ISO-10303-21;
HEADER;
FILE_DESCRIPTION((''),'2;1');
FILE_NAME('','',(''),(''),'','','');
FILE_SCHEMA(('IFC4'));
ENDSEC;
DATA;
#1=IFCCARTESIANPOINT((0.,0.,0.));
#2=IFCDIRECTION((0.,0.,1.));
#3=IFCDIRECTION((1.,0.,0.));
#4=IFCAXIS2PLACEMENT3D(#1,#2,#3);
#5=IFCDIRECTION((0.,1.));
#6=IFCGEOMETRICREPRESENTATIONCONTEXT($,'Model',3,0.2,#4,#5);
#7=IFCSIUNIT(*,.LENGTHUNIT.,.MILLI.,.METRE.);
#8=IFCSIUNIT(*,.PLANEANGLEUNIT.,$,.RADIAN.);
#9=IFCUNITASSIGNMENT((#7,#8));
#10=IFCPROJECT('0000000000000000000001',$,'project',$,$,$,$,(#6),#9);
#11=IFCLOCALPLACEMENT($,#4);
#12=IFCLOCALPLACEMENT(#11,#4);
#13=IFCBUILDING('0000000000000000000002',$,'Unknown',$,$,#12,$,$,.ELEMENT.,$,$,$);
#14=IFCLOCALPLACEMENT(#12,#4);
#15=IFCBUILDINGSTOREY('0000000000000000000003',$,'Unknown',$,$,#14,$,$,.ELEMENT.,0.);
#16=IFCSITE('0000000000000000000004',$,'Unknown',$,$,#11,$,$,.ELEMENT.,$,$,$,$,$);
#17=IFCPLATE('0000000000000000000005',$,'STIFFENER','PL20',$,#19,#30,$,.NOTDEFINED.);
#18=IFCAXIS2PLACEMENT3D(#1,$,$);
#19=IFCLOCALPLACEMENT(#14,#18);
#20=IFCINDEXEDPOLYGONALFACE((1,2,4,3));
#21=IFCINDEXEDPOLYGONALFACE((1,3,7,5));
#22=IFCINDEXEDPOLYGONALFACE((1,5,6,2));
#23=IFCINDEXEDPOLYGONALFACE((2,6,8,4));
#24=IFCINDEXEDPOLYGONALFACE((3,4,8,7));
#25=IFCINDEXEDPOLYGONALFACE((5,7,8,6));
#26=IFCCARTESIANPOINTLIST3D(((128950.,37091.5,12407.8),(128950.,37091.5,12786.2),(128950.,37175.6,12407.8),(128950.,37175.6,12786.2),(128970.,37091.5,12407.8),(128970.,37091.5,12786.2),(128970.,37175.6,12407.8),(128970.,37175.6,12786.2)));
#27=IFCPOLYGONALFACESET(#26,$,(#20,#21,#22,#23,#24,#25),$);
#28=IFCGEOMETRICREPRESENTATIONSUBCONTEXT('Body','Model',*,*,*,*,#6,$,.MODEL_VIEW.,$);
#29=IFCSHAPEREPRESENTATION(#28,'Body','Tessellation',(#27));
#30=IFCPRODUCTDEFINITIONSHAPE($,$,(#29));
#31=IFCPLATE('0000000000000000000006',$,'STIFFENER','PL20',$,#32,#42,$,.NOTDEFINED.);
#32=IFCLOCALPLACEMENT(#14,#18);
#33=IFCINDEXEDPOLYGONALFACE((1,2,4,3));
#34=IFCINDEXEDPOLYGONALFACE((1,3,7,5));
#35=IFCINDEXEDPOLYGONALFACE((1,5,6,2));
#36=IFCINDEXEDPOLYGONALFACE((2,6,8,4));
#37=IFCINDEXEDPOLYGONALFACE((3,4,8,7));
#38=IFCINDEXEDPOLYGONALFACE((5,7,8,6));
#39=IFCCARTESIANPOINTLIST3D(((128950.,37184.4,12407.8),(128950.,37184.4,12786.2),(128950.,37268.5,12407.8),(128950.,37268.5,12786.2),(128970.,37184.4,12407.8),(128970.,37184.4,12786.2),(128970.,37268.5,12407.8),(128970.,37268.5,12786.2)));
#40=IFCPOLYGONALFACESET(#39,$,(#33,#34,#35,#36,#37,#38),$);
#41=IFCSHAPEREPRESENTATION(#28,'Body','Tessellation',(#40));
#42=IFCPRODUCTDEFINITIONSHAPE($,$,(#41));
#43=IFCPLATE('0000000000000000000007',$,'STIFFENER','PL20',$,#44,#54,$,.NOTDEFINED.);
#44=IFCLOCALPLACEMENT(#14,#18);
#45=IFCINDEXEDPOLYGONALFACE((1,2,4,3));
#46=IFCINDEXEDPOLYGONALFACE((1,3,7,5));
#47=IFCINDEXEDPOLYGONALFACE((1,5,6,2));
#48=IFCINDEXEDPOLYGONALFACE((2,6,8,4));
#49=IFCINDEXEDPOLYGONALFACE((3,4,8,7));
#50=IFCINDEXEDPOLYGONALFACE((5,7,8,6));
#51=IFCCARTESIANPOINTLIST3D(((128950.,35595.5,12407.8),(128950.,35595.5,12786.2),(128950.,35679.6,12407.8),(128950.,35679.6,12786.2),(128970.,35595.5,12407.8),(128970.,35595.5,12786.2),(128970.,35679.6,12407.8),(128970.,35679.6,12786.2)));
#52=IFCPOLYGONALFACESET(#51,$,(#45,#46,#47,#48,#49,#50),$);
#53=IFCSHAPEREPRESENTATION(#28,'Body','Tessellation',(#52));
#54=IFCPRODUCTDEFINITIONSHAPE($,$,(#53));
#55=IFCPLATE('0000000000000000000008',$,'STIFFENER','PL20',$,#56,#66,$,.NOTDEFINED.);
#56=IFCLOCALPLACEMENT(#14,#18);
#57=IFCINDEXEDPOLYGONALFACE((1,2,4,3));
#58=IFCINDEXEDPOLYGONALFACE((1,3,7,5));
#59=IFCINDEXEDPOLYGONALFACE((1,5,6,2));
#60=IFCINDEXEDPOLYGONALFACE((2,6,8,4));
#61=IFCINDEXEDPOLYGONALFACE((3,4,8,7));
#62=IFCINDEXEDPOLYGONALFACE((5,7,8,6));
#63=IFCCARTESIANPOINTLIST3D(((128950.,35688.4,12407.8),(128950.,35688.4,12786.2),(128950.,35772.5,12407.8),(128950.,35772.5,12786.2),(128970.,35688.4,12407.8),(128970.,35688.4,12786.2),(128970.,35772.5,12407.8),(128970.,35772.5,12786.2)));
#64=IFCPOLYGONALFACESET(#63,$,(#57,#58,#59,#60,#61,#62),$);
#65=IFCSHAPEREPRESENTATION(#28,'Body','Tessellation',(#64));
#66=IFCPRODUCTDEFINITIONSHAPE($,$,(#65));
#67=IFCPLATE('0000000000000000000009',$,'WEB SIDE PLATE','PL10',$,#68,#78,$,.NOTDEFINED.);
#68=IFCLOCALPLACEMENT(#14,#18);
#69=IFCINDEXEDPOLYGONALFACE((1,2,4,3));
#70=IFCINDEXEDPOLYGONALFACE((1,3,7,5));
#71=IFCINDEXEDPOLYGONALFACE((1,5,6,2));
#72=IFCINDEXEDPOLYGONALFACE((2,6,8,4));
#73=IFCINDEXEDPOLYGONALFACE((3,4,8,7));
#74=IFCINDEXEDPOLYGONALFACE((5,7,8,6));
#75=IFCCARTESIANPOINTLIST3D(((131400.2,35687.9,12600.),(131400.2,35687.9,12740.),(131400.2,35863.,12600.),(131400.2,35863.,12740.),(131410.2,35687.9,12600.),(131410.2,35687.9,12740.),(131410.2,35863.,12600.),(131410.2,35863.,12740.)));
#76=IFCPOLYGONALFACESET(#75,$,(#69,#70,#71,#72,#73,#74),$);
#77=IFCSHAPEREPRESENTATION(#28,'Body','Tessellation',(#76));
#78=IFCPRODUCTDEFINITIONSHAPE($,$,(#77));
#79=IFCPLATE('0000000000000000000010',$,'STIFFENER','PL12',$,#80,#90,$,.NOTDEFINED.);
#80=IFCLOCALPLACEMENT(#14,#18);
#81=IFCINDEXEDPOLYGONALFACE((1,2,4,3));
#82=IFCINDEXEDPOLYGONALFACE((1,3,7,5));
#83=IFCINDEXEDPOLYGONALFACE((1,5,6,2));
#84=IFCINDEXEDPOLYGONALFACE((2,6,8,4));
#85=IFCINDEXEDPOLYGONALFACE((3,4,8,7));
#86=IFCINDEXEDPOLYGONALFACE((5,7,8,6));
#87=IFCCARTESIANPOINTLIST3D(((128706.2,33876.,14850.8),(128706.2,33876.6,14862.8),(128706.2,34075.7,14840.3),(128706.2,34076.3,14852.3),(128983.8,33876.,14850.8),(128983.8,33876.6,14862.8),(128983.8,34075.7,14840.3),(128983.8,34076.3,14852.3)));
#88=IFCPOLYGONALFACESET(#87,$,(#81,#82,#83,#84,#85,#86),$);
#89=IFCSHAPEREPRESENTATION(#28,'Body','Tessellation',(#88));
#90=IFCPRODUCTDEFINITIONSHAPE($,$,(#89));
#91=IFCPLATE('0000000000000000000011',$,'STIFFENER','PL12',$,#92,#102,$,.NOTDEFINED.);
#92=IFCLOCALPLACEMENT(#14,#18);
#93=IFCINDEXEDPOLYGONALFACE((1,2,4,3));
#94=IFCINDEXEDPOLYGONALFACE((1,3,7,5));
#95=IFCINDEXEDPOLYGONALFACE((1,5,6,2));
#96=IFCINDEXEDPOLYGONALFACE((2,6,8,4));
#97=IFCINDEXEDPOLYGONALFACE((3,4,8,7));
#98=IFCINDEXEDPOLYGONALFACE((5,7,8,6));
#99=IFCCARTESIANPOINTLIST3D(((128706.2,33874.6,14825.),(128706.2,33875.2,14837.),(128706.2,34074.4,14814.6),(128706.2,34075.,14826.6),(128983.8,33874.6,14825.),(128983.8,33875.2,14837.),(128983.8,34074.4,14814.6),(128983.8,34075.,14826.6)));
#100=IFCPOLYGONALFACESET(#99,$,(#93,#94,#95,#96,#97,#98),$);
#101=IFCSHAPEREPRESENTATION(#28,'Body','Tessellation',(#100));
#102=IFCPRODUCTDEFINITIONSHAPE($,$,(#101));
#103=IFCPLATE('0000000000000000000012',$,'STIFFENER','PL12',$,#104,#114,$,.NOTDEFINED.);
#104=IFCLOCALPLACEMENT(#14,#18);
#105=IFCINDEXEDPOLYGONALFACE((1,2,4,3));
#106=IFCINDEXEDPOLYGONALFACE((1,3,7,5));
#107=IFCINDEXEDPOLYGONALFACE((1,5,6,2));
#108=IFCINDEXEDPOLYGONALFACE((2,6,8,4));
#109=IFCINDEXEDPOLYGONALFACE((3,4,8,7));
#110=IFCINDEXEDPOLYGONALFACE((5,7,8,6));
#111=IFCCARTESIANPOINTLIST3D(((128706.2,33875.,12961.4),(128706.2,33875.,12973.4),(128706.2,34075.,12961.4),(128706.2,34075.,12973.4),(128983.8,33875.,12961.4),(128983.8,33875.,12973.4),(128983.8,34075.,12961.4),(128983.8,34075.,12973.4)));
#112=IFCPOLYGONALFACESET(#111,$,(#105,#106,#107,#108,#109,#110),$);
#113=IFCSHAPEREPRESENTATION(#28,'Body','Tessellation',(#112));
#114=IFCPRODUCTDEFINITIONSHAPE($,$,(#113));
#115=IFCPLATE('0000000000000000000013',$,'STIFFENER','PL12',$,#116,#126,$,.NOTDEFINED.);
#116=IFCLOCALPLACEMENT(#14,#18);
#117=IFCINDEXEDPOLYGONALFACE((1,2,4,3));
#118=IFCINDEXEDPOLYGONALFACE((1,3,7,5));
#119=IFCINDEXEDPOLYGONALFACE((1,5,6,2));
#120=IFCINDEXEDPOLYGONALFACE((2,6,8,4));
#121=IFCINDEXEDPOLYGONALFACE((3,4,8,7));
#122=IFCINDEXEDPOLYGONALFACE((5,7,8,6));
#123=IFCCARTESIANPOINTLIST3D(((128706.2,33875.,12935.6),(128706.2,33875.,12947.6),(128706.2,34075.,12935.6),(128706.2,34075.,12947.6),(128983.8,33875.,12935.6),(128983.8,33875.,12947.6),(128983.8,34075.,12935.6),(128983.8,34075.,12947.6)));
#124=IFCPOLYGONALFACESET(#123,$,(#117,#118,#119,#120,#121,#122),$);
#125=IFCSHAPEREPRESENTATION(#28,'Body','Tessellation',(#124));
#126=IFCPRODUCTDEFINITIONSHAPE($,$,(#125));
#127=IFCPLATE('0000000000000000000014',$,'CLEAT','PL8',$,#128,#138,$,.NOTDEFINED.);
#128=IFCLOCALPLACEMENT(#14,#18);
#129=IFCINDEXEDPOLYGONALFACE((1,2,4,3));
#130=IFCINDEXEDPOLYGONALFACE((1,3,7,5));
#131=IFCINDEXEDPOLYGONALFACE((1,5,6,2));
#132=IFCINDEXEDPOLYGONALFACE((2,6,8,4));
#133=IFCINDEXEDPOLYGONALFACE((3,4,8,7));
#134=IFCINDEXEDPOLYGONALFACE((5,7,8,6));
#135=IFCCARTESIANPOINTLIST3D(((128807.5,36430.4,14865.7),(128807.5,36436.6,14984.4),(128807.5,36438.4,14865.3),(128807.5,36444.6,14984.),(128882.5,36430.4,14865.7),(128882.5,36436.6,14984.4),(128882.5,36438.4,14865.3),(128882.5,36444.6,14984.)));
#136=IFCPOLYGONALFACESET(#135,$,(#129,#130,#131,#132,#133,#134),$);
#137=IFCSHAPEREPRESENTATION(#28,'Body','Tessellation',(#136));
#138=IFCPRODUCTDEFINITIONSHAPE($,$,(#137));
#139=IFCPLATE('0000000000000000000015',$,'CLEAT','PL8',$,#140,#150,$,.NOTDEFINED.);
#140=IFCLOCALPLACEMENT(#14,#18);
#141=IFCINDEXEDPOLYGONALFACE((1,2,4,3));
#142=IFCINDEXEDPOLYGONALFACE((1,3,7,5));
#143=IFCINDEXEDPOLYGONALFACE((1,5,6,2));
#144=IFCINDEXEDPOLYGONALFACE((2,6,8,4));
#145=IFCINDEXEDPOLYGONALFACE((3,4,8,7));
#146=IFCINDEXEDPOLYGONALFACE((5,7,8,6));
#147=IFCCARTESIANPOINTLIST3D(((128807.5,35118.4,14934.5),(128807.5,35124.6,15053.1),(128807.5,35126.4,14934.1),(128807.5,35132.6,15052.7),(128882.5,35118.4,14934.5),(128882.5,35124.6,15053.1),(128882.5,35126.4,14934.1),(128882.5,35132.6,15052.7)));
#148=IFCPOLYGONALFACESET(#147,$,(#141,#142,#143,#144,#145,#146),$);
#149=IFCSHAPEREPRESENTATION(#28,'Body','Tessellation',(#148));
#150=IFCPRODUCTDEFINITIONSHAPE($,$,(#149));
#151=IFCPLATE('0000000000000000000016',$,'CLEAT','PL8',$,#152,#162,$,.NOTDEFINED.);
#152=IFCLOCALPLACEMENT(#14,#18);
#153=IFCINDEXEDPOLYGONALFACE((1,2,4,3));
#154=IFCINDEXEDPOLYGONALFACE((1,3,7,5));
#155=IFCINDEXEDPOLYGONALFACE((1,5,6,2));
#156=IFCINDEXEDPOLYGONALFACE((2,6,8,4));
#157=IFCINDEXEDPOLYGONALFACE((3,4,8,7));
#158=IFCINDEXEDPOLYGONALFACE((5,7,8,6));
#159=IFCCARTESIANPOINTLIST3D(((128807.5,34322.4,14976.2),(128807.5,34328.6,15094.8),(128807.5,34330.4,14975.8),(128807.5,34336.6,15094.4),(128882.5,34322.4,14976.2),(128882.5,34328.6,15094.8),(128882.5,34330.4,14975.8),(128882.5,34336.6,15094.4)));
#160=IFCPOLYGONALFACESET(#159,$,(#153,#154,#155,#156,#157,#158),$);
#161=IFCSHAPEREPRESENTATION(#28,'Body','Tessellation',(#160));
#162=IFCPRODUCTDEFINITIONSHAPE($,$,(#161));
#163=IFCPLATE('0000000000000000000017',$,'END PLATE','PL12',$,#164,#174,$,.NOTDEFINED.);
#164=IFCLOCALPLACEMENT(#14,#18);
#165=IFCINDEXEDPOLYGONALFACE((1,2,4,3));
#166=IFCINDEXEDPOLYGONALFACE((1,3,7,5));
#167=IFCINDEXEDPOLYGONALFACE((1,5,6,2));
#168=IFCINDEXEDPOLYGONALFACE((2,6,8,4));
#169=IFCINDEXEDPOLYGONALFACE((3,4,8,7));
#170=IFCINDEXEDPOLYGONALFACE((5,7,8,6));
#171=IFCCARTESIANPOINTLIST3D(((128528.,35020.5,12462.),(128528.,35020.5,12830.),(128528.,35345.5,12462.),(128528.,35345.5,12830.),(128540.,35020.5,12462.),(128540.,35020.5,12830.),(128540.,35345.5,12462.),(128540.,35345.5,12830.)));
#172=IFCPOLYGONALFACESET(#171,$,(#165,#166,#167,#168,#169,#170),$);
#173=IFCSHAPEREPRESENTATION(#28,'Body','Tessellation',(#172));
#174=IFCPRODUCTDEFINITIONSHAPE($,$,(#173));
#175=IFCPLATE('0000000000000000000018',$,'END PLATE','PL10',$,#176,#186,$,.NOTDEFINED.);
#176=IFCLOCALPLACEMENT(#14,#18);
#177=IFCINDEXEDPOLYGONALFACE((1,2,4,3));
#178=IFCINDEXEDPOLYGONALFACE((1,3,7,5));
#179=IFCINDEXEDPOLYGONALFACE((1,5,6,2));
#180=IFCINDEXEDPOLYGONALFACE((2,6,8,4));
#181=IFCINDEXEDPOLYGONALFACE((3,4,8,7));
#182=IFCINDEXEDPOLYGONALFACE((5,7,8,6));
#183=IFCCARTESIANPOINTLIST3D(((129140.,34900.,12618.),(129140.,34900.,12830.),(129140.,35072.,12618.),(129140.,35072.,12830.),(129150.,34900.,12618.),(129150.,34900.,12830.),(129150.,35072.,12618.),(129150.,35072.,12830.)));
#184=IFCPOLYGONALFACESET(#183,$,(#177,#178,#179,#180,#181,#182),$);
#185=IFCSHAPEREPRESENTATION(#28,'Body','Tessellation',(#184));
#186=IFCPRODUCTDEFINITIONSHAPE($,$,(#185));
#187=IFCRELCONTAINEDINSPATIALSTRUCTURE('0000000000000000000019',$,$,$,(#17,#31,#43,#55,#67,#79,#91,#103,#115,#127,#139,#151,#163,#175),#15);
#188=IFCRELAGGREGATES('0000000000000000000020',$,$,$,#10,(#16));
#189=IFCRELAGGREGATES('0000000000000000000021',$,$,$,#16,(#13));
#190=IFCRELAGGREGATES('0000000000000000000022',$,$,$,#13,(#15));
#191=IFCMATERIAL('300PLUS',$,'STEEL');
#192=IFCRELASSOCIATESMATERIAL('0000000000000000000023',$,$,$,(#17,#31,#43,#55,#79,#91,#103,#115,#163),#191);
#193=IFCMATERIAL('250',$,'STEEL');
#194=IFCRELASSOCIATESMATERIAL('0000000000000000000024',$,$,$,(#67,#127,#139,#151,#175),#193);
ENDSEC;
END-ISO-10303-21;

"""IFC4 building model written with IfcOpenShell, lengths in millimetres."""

from ifc_helpers import new_model, si_unit, direction, frame, origin_with_axes, place, context, subcontext, project, spatial, line, indexed_curve, outline, extrude, material, element, save


model = new_model("IFC4")

# Units and contexts
model_context = context("Model", 3, precision=0.2, world=origin_with_axes(), true_north=direction((0.0, 1.0)))
body_context = subcontext(model_context, "Body", "Model", "MODEL_VIEW")
ifc_project = project(units=[si_unit("LENGTHUNIT", "METRE", prefix="MILLI"), si_unit("PLANEANGLEUNIT", "RADIAN")], contexts=[model_context])

# Site, building, storey
site_placement = place(None, origin_with_axes())
site = spatial("IfcSite", under=ifc_project, at=site_placement, Name="Unknown", CompositionType="ELEMENT")
building_placement = place(site_placement, origin_with_axes())
building = spatial("IfcBuilding", under=site, at=building_placement, Name="Unknown", CompositionType="ELEMENT")
storey_placement = place(building_placement, origin_with_axes())
storey = spatial("IfcBuildingStorey", under=building, at=storey_placement, Name="Unknown", CompositionType="ELEMENT", Elevation=0.0)

# Shared definitions
ifc_material_1 = material(Name="300PLUS", Category="STEEL")

# Plates
for number, where, z_axis, x_axis, name in (
    (1, (128960.0, 37175.6, 12407.8), (1.0, 0.0, 0.0), (0.0, 0.0, 1.0), "STIFFENER"),
    (2, (128960.0, 37268.5, 12407.8), (1.0, 0.0, 0.0), (0.0, 0.0, 1.0), "STIFFENER"),
    (3, (128960.0, 35679.6, 12407.8), (1.0, 0.0, 0.0), (0.0, 0.0, 1.0), "STIFFENER"),
    (4, (128960.0, 35772.5, 12407.8), (1.0, 0.0, 0.0), (0.0, 0.0, 1.0), "STIFFENER"),
):
    element("IfcPlate", number, at=place(storey_placement, frame(where, z_axis=z_axis, x_axis=x_axis)), inside=storey, material=ifc_material_1, Name=name, Description="PL20", PredefinedType="NOTDEFINED", context=body_context, shape_type="SolidModel", body=[
        extrude(outline(indexed_curve([(0.0, 0.0), (378.4, 0.0), (378.4, 84.1), (0.0, 84.1)], segments=[line(1, 2, 3, 4, 1)])), frame((0.0, 0.0, 10.0), z_axis=(0.0, 0.0, 1.0), x_axis=(1.0, 0.0, 0.0)), (0.0, 0.0, -1.0), 20.0),
    ])
ifc_material_2 = material(Name="250", Category="STEEL")
plate_1_placement = place(storey_placement, frame((131405.2, 35863.0, 12600.0), z_axis=(1.0, 0.0, 0.0), x_axis=(0.0, 0.0, 1.0)))
element("IfcPlate", 5, at=plate_1_placement, inside=storey, material=ifc_material_2, Name="WEB SIDE PLATE", Description="PL10", PredefinedType="NOTDEFINED", context=body_context, shape_type="SolidModel", body=[
    extrude(outline(indexed_curve([(0.0, 0.0), (140.0, 0.0), (140.0, 175.1), (0.0, 175.1)], segments=[line(1, 2, 3, 4, 1)])), frame((0.0, 0.0, 5.0), z_axis=(0.0, 0.0, 1.0), x_axis=(1.0, 0.0, 0.0)), (0.0, 0.0, -1.0), 10.0),
])
plate_2_placement = place(storey_placement, frame((128706.2, 34076.0, 14846.3), z_axis=(0.0, 0.052506, 0.998621), x_axis=(0.0, -0.998621, 0.052506)))
element("IfcPlate", 6, at=plate_2_placement, inside=storey, material=ifc_material_1, Name="STIFFENER", Description="PL12", PredefinedType="NOTDEFINED", context=body_context, shape_type="SolidModel", body=[
    extrude(outline(indexed_curve([(0.0, 0.0), (200.0, 0.0), (200.0, 277.6), (0.0, 277.6)], segments=[line(1, 2, 3, 4, 1)])), frame((0.0, 0.0, 6.0), z_axis=(0.0, 0.0, 1.0), x_axis=(1.0, 0.0, 0.0)), (0.0, 0.0, -1.0), 12.0),
])
plate_3_placement = place(storey_placement, frame((128706.2, 34074.7, 14820.6), z_axis=(0.0, 0.051982, 0.998648), x_axis=(0.0, -0.998648, 0.051982)))
element("IfcPlate", 7, at=plate_3_placement, inside=storey, material=ifc_material_1, Name="STIFFENER", Description="PL12", PredefinedType="NOTDEFINED", context=body_context, shape_type="SolidModel", body=[
    extrude(outline(indexed_curve([(0.0, 0.0), (200.1, 0.0), (200.1, 277.6), (0.0, 277.6)], segments=[line(1, 2, 3, 4, 1)])), frame((0.0, 0.0, 6.0), z_axis=(0.0, 0.0, 1.0), x_axis=(1.0, 0.0, 0.0)), (0.0, 0.0, -1.0), 12.0),
])
for number, where, z_axis, x_axis, name in (
    (8, (128706.2, 34075.0, 12967.4), (0.0, 0.0, 1.0), (0.0, -1.0, 0.0), "STIFFENER"),
    (9, (128706.2, 34075.0, 12941.6), (0.0, 0.0, 1.0), (0.0, -1.0, 0.0), "STIFFENER"),
):
    element("IfcPlate", number, at=place(storey_placement, frame(where, z_axis=z_axis, x_axis=x_axis)), inside=storey, material=ifc_material_1, Name=name, Description="PL12", PredefinedType="NOTDEFINED", context=body_context, shape_type="SolidModel", body=[
        extrude(outline(indexed_curve([(0.0, 0.0), (200.0, 0.0), (200.0, 277.6), (0.0, 277.6)], segments=[line(1, 2, 3, 4, 1)])), frame((0.0, 0.0, 6.0), z_axis=(0.0, 0.0, 1.0), x_axis=(1.0, 0.0, 0.0)), (0.0, 0.0, -1.0), 12.0),
    ])
plate_4_placement = place(storey_placement, frame((128807.5, 36434.4, 14865.5), z_axis=(0.0, -0.998639, 0.052161), x_axis=(1.0, 0.0, 0.0)))
element("IfcPlate", 10, at=plate_4_placement, inside=storey, material=ifc_material_2, Name="CLEAT", Description="PL8", PredefinedType="NOTDEFINED", context=body_context, shape_type="SolidModel", body=[
    extrude(outline(indexed_curve([(0.0, 0.0), (75.0, 0.0), (75.0, 118.9), (0.0, 118.9)], segments=[line(1, 2, 3, 4, 1)])), frame((0.0, 0.0, 4.0), z_axis=(0.0, 0.0, 1.0), x_axis=(1.0, 0.0, 0.0)), (0.0, 0.0, -1.0), 8.0),
])
for number, where, z_axis, x_axis, name in (
    (11, (128807.5, 35122.4, 14934.3), (0.0, -0.998636, 0.052205), (1.0, 0.0, 0.0), "CLEAT"),
    (12, (128807.5, 34326.4, 14976.0), (0.0, -0.998636, 0.052205), (1.0, 0.0, 0.0), "CLEAT"),
):
    element("IfcPlate", number, at=place(storey_placement, frame(where, z_axis=z_axis, x_axis=x_axis)), inside=storey, material=ifc_material_2, Name=name, Description="PL8", PredefinedType="NOTDEFINED", context=body_context, shape_type="SolidModel", body=[
        extrude(outline(indexed_curve([(0.0, 0.0), (75.0, 0.0), (75.0, 118.8), (0.0, 118.8)], segments=[line(1, 2, 3, 4, 1)])), frame((0.0, 0.0, 4.0), z_axis=(0.0, 0.0, 1.0), x_axis=(1.0, 0.0, 0.0)), (0.0, 0.0, -1.0), 8.0),
    ])
plate_5_placement = place(storey_placement, frame((128534.0, 35345.5, 12462.0), z_axis=(-1.0, 0.0, 0.0), x_axis=(0.0, -1.0, 0.0)))
element("IfcPlate", 13, at=plate_5_placement, inside=storey, material=ifc_material_1, Name="END PLATE", Description="PL12", PredefinedType="NOTDEFINED", context=body_context, shape_type="SolidModel", body=[
    extrude(outline(indexed_curve([(0.0, 0.0), (325.0, 0.0), (325.0, 368.0), (0.0, 368.0)], segments=[line(1, 2, 3, 4, 1)])), frame((0.0, 0.0, 6.0), z_axis=(0.0, 0.0, 1.0), x_axis=(1.0, 0.0, 0.0)), (0.0, 0.0, -1.0), 12.0),
])
plate_6_placement = place(storey_placement, frame((129145.0, 35072.0, 12618.0), z_axis=(-1.0, 0.0, 0.0), x_axis=(0.0, -1.0, 0.0)))
element("IfcPlate", 14, at=plate_6_placement, inside=storey, material=ifc_material_2, Name="END PLATE", Description="PL10", PredefinedType="NOTDEFINED", context=body_context, shape_type="SolidModel", body=[
    extrude(outline(indexed_curve([(0.0, 0.0), (172.0, 0.0), (172.0, 212.0), (0.0, 212.0)], segments=[line(1, 2, 3, 4, 1)])), frame((0.0, 0.0, 5.0), z_axis=(0.0, 0.0, 1.0), x_axis=(1.0, 0.0, 0.0)), (0.0, 0.0, -1.0), 10.0),
])

save(model, "model.ifc")
